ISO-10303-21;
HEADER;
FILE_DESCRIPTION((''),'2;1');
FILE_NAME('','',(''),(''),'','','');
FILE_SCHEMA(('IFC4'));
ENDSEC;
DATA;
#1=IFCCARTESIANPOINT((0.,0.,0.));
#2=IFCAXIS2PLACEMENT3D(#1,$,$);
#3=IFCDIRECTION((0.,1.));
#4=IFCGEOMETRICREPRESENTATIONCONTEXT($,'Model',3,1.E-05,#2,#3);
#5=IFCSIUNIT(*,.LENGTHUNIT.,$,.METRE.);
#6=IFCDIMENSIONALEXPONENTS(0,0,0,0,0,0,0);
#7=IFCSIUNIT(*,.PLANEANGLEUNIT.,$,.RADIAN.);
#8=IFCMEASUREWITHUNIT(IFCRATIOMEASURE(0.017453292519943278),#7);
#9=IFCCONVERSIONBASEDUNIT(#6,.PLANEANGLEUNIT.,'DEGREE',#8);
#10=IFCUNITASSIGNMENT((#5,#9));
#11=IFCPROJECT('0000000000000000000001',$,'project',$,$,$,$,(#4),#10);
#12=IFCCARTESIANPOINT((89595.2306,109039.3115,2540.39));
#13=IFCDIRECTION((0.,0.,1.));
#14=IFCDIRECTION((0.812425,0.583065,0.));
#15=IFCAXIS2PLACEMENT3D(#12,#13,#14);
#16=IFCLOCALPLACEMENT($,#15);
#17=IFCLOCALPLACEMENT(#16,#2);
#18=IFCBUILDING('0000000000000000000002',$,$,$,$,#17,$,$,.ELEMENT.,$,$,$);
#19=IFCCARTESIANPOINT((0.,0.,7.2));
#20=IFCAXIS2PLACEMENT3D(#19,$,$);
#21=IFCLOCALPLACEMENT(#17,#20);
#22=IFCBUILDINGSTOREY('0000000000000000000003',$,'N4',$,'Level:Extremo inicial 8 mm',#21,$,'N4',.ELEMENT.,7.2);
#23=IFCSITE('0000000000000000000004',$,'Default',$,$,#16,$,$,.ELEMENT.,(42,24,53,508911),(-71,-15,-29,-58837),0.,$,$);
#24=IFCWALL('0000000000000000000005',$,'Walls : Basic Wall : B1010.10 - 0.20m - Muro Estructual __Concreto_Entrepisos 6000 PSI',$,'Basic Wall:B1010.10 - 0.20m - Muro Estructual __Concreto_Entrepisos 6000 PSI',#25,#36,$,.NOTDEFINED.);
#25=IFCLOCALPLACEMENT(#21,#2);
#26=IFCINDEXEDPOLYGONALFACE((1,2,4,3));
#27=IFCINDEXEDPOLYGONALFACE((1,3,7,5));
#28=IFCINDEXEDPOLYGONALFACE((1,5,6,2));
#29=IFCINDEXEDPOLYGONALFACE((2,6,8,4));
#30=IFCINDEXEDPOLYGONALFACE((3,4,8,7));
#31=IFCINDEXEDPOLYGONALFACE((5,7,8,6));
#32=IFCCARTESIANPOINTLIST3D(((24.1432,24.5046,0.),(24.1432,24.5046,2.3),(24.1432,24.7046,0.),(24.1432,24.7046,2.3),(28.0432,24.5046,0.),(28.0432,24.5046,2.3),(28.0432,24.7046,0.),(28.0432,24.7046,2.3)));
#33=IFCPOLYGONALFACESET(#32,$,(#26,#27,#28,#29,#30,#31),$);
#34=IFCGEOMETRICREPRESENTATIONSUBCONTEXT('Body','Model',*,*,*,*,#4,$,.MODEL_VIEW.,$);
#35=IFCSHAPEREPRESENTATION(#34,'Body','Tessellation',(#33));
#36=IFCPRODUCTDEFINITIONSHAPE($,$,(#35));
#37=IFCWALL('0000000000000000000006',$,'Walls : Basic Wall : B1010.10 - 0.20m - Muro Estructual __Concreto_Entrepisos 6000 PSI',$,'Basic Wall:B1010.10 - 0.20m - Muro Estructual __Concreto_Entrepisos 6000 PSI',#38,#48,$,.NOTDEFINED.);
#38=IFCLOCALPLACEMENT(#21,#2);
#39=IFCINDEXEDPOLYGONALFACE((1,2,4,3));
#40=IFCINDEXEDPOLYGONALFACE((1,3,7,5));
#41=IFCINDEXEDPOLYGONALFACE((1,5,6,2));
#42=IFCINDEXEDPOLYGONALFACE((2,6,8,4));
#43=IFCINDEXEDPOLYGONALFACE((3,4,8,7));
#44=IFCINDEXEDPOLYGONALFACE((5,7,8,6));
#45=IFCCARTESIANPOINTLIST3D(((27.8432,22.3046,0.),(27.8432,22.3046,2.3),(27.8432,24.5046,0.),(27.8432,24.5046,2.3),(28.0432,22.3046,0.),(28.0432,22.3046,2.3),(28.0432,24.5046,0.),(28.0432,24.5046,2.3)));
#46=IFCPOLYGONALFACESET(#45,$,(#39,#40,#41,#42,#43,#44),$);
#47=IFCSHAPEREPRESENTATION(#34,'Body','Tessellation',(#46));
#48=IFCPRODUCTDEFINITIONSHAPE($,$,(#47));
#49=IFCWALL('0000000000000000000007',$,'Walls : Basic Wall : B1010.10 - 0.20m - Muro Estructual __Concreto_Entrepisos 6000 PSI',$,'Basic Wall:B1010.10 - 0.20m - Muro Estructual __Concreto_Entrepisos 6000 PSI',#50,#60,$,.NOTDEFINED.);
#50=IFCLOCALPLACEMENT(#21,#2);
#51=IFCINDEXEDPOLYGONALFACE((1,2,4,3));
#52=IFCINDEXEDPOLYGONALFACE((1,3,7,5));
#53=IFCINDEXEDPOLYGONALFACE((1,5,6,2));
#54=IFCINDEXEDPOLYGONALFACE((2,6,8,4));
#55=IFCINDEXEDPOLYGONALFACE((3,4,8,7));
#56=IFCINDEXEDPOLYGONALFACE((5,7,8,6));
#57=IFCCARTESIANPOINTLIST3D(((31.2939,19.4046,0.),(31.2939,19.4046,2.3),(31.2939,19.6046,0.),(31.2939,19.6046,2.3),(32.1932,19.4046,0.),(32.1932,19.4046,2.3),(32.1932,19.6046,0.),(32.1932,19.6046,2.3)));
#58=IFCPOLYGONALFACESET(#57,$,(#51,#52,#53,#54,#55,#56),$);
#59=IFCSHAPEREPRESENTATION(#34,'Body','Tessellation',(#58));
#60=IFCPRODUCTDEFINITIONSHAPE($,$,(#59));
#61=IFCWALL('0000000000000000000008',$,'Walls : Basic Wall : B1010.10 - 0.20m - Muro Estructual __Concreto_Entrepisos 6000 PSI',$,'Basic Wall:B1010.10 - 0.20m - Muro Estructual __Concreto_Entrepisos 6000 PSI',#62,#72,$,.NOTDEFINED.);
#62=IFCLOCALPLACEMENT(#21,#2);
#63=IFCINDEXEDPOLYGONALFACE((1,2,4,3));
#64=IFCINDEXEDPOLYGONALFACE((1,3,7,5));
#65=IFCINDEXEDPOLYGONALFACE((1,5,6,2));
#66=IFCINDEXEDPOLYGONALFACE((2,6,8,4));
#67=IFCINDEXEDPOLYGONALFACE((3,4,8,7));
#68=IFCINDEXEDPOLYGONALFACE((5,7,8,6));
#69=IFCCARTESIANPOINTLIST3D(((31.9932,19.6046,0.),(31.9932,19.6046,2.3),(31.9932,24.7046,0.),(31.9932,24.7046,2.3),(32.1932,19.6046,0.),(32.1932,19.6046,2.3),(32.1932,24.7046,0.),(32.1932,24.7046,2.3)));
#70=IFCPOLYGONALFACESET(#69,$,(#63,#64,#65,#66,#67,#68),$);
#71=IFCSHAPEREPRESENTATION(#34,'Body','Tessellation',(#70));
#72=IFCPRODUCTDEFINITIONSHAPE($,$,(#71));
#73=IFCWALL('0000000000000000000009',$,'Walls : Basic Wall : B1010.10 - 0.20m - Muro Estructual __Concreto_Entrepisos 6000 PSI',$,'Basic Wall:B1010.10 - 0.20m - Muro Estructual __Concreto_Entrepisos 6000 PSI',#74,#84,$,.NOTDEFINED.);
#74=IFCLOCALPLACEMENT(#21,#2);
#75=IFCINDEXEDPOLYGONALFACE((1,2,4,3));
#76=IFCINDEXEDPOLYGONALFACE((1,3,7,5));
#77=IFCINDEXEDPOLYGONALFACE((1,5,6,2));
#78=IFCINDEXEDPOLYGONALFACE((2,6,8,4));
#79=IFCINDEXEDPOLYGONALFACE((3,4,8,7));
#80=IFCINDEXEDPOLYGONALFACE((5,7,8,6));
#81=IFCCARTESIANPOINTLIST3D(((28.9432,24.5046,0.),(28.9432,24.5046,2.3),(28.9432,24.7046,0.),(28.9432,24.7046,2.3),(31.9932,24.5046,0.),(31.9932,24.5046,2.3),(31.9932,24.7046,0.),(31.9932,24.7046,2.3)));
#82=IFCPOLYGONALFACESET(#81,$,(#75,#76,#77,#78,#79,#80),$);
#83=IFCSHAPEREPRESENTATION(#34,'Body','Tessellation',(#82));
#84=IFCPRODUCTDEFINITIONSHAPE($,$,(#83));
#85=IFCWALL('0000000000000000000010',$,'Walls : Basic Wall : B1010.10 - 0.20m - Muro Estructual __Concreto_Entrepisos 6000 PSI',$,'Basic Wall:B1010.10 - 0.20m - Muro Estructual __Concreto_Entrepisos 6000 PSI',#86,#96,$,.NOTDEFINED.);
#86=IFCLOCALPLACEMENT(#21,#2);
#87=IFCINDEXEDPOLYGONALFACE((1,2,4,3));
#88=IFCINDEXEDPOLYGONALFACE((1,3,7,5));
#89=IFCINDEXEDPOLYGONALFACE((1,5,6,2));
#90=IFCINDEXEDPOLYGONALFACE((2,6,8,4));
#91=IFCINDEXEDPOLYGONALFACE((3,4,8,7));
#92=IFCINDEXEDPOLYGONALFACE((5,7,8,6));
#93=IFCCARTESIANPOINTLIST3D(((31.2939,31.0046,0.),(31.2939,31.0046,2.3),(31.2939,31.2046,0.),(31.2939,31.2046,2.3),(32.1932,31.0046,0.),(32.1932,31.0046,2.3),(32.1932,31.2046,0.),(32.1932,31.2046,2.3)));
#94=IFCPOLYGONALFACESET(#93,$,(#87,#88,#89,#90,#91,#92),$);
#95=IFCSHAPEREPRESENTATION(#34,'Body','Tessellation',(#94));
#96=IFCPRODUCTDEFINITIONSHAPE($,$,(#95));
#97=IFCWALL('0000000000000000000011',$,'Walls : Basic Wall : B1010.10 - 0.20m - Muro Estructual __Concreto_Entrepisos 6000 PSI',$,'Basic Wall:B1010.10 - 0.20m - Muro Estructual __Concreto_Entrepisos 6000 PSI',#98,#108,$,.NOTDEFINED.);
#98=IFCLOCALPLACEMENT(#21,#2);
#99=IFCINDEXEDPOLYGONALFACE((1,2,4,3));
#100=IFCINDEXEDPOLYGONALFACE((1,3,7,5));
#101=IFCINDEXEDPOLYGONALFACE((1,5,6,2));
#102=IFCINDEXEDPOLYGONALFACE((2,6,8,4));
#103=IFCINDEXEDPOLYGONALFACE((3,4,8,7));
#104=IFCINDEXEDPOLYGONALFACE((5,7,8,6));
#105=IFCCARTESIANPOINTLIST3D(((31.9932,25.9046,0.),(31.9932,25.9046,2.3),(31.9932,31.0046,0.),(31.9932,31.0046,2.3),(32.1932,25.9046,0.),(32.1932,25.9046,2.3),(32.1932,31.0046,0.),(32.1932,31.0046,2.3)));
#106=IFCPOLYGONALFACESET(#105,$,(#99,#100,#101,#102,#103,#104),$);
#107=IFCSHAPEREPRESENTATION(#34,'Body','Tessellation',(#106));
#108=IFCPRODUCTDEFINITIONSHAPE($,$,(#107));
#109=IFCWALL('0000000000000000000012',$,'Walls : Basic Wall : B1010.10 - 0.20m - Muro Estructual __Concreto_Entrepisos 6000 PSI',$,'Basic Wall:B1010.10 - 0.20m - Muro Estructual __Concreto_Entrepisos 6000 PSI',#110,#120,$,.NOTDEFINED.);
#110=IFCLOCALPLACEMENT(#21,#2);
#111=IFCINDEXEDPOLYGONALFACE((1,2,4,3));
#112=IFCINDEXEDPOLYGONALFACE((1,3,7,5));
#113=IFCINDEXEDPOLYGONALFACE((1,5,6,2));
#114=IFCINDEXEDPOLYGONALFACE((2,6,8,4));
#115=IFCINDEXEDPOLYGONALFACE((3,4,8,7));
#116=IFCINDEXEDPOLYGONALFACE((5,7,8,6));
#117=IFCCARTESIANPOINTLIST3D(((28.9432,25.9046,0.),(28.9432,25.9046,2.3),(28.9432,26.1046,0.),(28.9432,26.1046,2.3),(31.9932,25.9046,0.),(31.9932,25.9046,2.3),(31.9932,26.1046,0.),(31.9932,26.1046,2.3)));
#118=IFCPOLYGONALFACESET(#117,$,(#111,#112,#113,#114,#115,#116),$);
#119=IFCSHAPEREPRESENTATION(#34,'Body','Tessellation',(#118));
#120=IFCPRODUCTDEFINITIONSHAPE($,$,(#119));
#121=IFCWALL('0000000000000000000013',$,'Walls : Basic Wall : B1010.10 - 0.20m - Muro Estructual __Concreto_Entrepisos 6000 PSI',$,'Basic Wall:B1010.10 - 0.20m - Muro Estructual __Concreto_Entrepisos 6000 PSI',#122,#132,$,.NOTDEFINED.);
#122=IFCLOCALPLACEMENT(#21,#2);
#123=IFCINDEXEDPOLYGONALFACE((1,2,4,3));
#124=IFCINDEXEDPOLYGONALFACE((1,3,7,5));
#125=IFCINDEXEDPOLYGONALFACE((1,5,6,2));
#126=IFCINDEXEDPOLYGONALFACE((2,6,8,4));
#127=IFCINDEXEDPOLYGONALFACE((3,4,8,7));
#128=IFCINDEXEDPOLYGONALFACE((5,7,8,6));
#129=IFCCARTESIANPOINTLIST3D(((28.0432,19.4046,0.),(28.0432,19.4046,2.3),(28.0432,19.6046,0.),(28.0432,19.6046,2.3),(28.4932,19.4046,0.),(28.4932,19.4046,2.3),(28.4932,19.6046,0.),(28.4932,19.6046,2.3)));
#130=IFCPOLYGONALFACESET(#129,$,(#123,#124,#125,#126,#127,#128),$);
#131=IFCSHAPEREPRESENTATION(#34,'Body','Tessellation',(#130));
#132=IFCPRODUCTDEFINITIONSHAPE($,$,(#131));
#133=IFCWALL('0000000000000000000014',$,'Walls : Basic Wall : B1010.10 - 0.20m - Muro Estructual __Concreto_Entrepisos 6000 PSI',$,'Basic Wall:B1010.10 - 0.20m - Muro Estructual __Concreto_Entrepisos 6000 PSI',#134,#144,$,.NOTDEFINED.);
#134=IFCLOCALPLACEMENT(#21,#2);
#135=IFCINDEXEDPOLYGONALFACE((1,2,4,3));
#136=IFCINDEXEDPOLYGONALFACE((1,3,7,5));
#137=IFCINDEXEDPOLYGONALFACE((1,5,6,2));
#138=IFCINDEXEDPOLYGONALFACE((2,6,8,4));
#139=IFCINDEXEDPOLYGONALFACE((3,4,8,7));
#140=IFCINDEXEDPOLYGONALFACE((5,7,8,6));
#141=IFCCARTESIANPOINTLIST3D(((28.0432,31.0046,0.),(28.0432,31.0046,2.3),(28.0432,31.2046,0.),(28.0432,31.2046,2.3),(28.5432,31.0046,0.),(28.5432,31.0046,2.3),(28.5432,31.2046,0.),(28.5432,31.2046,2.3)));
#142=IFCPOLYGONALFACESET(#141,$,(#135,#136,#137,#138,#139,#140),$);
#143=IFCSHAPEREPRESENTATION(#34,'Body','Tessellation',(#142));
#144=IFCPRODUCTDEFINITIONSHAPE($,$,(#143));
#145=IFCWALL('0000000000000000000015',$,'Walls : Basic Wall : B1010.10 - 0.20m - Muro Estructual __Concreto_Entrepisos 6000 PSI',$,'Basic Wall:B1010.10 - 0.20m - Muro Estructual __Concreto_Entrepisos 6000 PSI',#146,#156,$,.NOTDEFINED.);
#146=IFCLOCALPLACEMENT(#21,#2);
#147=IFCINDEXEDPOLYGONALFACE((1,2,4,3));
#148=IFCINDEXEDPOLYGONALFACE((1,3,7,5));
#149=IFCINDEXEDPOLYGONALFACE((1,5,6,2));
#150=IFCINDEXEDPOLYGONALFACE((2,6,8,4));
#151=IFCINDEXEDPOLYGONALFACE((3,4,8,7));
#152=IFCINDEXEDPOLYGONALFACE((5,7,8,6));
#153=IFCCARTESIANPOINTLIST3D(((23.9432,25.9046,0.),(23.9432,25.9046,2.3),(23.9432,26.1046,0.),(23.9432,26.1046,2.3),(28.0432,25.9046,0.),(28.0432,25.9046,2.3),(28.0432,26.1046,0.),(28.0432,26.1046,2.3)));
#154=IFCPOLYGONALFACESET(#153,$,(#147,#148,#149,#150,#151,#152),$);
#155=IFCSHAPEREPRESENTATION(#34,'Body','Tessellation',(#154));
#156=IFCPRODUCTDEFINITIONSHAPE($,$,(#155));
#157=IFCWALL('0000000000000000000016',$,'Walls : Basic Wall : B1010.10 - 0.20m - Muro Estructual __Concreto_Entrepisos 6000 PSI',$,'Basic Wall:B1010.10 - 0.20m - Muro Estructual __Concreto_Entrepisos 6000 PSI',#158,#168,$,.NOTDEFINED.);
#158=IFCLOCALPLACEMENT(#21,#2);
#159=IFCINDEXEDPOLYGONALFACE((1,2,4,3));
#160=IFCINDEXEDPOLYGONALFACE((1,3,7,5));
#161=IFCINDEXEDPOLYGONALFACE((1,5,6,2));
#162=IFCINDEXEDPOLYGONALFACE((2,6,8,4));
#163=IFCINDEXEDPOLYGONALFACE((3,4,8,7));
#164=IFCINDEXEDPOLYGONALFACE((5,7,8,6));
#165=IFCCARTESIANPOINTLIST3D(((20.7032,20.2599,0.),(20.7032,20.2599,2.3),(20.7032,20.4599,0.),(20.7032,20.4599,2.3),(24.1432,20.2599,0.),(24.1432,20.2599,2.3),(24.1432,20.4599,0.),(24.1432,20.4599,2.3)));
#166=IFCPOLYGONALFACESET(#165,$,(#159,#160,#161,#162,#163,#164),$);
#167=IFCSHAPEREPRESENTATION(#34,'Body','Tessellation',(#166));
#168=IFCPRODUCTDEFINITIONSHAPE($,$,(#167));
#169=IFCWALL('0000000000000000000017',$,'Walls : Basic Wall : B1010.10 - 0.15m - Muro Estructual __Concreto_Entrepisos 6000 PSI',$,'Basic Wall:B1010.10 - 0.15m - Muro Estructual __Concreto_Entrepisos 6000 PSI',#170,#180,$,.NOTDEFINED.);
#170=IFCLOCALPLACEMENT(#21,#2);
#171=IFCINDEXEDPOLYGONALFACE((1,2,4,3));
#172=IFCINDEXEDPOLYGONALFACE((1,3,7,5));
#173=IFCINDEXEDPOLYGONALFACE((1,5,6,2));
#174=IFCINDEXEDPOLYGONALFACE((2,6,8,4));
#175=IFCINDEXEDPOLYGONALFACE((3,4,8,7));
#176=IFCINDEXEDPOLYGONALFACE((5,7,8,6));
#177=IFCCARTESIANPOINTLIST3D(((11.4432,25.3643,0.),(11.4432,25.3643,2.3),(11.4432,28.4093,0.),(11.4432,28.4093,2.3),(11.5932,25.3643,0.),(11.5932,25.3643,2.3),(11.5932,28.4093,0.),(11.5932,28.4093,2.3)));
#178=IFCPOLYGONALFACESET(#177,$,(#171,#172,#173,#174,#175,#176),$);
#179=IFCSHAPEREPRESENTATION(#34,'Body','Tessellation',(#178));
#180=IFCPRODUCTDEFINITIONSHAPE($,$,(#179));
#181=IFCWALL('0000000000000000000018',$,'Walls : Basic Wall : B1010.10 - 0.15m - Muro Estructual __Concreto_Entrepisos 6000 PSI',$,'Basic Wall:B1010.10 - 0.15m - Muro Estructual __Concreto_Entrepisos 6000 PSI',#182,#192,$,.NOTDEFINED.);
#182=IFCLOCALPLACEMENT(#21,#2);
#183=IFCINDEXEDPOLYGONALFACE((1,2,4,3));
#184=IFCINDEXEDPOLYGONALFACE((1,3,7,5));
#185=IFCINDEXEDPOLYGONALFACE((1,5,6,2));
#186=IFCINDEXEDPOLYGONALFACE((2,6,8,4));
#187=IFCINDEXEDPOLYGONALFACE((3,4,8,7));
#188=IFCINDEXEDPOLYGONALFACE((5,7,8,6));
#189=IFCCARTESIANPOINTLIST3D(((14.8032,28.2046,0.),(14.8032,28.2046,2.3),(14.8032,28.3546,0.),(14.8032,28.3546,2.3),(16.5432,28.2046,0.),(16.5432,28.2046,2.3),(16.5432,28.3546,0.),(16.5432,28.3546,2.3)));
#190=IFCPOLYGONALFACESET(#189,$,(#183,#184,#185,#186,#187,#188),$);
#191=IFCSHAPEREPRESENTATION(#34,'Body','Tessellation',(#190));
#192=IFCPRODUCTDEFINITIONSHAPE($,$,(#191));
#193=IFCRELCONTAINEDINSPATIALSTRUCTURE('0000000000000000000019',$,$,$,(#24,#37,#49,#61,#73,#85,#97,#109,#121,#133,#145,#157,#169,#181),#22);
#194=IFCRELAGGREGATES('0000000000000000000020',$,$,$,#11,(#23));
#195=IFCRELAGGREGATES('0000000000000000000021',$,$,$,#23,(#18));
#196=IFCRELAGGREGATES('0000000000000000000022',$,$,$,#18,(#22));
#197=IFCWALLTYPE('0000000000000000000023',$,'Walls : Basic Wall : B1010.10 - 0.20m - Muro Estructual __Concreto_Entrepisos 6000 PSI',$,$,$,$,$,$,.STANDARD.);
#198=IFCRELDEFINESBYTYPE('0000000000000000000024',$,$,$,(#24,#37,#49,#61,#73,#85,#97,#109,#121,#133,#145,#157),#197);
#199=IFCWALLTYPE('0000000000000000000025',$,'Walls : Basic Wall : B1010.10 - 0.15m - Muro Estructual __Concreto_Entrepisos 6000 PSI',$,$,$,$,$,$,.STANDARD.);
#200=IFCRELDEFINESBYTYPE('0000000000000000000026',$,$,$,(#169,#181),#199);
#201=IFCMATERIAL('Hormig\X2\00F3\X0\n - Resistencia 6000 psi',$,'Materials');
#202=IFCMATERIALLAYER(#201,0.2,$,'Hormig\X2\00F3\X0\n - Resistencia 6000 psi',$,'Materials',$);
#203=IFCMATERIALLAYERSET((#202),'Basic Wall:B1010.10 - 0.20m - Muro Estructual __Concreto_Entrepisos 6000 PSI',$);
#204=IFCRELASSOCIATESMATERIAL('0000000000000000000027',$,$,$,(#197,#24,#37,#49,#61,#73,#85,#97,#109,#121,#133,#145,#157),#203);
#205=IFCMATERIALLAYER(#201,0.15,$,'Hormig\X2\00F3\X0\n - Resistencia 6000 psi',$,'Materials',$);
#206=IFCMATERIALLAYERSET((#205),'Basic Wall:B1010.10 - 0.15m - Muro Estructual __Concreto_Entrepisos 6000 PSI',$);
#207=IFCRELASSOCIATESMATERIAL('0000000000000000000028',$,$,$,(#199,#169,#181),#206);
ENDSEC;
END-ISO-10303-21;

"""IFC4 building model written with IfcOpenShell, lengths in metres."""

from ifc_helpers import new_model, entity, si_unit, converted_unit, direction, frame, frame_2d, origin, place, context, subcontext, project, spatial, rectangle, extrude, material, layer, layer_set, layer_usage, type_object, element, save


model = new_model("IFC4")

# Units and contexts
model_context = context("Model", 3, precision=1e-05, world=origin(), true_north=direction((0.0, 1.0)))
body_context = subcontext(model_context, "Body", "Model", "MODEL_VIEW")
ifc_project = project(units=[si_unit("LENGTHUNIT", "METRE"), converted_unit("PLANEANGLEUNIT", "DEGREE", entity("IfcRatioMeasure", 0.017453292519943278), si_unit("PLANEANGLEUNIT", "RADIAN"), dimensions=[0, 0, 0, 0, 0, 0, 0])], contexts=[model_context])

# Site, building, storey
site_placement = place(None, frame((89595.2306, 109039.3115, 2540.39), z_axis=(0.0, 0.0, 1.0), x_axis=(0.812425, 0.583065, 0.0)))
site = spatial("IfcSite", under=ifc_project, at=site_placement, Name="Default", CompositionType="ELEMENT", RefLatitude=(42, 24, 53, 508911), RefLongitude=(-71, -15, -29, -58837), RefElevation=0.0)
building_placement = place(site_placement, origin())
building = spatial("IfcBuilding", under=site, at=building_placement, CompositionType="ELEMENT")
storey_placement = place(building_placement, frame((0.0, 0.0, 7.2)))
storey = spatial("IfcBuildingStorey", under=building, at=storey_placement, Name="N4", ObjectType="Level:Extremo inicial 8 mm", LongName="N4", CompositionType="ELEMENT", Elevation=7.2)

# Walls
ifc_material_1 = material(Name="Hormigón - Resistencia 6000 psi", Category="Materials")
ifc_layer_1 = layer(ifc_material_1, 0.2, Name="Hormigón - Resistencia 6000 psi", Category="Materials")
ifc_layer_set_1 = layer_set([ifc_layer_1], Name="Basic Wall:B1010.10 - 0.20m - Muro Estructual __Concreto_Entrepisos 6000 PSI")
wall_type_1 = type_object("IfcWallType", Name="Walls : Basic Wall : B1010.10 - 0.20m - Muro Estructual __Concreto_Entrepisos 6000 PSI", PredefinedType="STANDARD", material=ifc_layer_set_1)
ifc_layer_usage_1 = layer_usage(ifc_layer_set_1, "AXIS2", "NEGATIVE", 0.1)
wall_1_placement = place(storey_placement, frame((24.1432, 24.6046, 0.0)))
element("IfcWall", 1, at=wall_1_placement, inside=storey, type_object=wall_type_1, material=ifc_layer_usage_1, Name="Walls : Basic Wall : B1010.10 - 0.20m - Muro Estructual __Concreto_Entrepisos 6000 PSI", ObjectType="Basic Wall:B1010.10 - 0.20m - Muro Estructual __Concreto_Entrepisos 6000 PSI", PredefinedType="NOTDEFINED", context=body_context, shape_type="SweptSolid", body=[
    extrude(rectangle(XDim=3.9, YDim=0.2, at=frame_2d((1.95, 0.0), x_axis=(-1.0, 0.0))), origin(), (0.0, 0.0, 1.0), 2.3),
])
ifc_layer_usage_2 = layer_usage(ifc_layer_set_1, "AXIS2", "NEGATIVE", 0.1)
wall_2_placement = place(storey_placement, frame((27.9432, 24.5046, 0.0), z_axis=(0.0, 0.0, 1.0), x_axis=(0.0, -1.0, 0.0)))
element("IfcWall", 2, at=wall_2_placement, inside=storey, type_object=wall_type_1, material=ifc_layer_usage_2, Name="Walls : Basic Wall : B1010.10 - 0.20m - Muro Estructual __Concreto_Entrepisos 6000 PSI", ObjectType="Basic Wall:B1010.10 - 0.20m - Muro Estructual __Concreto_Entrepisos 6000 PSI", PredefinedType="NOTDEFINED", context=body_context, shape_type="SweptSolid", body=[
    extrude(rectangle(XDim=2.2, YDim=0.2, at=frame_2d((1.1, 0.0), x_axis=(-1.0, 0.0))), origin(), (0.0, 0.0, 1.0), 2.3),
])
ifc_layer_usage_3 = layer_usage(ifc_layer_set_1, "AXIS2", "NEGATIVE", 0.1)
wall_3_placement = place(storey_placement, frame((31.2939, 19.5046, 0.0)))
element("IfcWall", 3, at=wall_3_placement, inside=storey, type_object=wall_type_1, material=ifc_layer_usage_3, Name="Walls : Basic Wall : B1010.10 - 0.20m - Muro Estructual __Concreto_Entrepisos 6000 PSI", ObjectType="Basic Wall:B1010.10 - 0.20m - Muro Estructual __Concreto_Entrepisos 6000 PSI", PredefinedType="NOTDEFINED", context=body_context, shape_type="SweptSolid", body=[
    extrude(rectangle(XDim=0.8993, YDim=0.2, at=frame_2d((0.4497, 0.0), x_axis=(-1.0, 0.0))), origin(), (0.0, 0.0, 1.0), 2.3),
])
ifc_layer_usage_4 = layer_usage(ifc_layer_set_1, "AXIS2", "NEGATIVE", 0.1)
wall_4_placement = place(storey_placement, frame((32.0932, 19.6046, 0.0), z_axis=(0.0, 0.0, 1.0), x_axis=(0.0, 1.0, 0.0)))
element("IfcWall", 4, at=wall_4_placement, inside=storey, type_object=wall_type_1, material=ifc_layer_usage_4, Name="Walls : Basic Wall : B1010.10 - 0.20m - Muro Estructual __Concreto_Entrepisos 6000 PSI", ObjectType="Basic Wall:B1010.10 - 0.20m - Muro Estructual __Concreto_Entrepisos 6000 PSI", PredefinedType="NOTDEFINED", context=body_context, shape_type="SweptSolid", body=[
    extrude(rectangle(XDim=5.1, YDim=0.2, at=frame_2d((2.55, 0.0), x_axis=(-1.0, 0.0))), origin(), (0.0, 0.0, 1.0), 2.3),
])
ifc_layer_usage_5 = layer_usage(ifc_layer_set_1, "AXIS2", "NEGATIVE", 0.1)
wall_5_placement = place(storey_placement, frame((31.9932, 24.6046, 0.0), z_axis=(0.0, 0.0, 1.0), x_axis=(-1.0, 0.0, 0.0)))
element("IfcWall", 5, at=wall_5_placement, inside=storey, type_object=wall_type_1, material=ifc_layer_usage_5, Name="Walls : Basic Wall : B1010.10 - 0.20m - Muro Estructual __Concreto_Entrepisos 6000 PSI", ObjectType="Basic Wall:B1010.10 - 0.20m - Muro Estructual __Concreto_Entrepisos 6000 PSI", PredefinedType="NOTDEFINED", context=body_context, shape_type="SweptSolid", body=[
    extrude(rectangle(XDim=3.05, YDim=0.2, at=frame_2d((1.525, 0.0), x_axis=(-1.0, 0.0))), origin(), (0.0, 0.0, 1.0), 2.3),
])
ifc_layer_usage_6 = layer_usage(ifc_layer_set_1, "AXIS2", "POSITIVE", -0.1)
wall_6_placement = place(storey_placement, frame((31.2939, 31.1046, 0.0)))
element("IfcWall", 6, at=wall_6_placement, inside=storey, type_object=wall_type_1, material=ifc_layer_usage_6, Name="Walls : Basic Wall : B1010.10 - 0.20m - Muro Estructual __Concreto_Entrepisos 6000 PSI", ObjectType="Basic Wall:B1010.10 - 0.20m - Muro Estructual __Concreto_Entrepisos 6000 PSI", PredefinedType="NOTDEFINED", context=body_context, shape_type="SweptSolid", body=[
    extrude(rectangle(XDim=0.8993, YDim=0.2, at=frame_2d((0.4497, 0.0), x_axis=(-1.0, 0.0))), origin(), (0.0, 0.0, 1.0), 2.3),
])
ifc_layer_usage_7 = layer_usage(ifc_layer_set_1, "AXIS2", "POSITIVE", -0.1)
wall_7_placement = place(storey_placement, frame((32.0932, 31.0046, 0.0), z_axis=(0.0, 0.0, 1.0), x_axis=(0.0, -1.0, 0.0)))
element("IfcWall", 7, at=wall_7_placement, inside=storey, type_object=wall_type_1, material=ifc_layer_usage_7, Name="Walls : Basic Wall : B1010.10 - 0.20m - Muro Estructual __Concreto_Entrepisos 6000 PSI", ObjectType="Basic Wall:B1010.10 - 0.20m - Muro Estructual __Concreto_Entrepisos 6000 PSI", PredefinedType="NOTDEFINED", context=body_context, shape_type="SweptSolid", body=[
    extrude(rectangle(XDim=5.1, YDim=0.2, at=frame_2d((2.55, 0.0), x_axis=(-1.0, 0.0))), origin(), (0.0, 0.0, 1.0), 2.3),
])
ifc_layer_usage_8 = layer_usage(ifc_layer_set_1, "AXIS2", "POSITIVE", -0.1)
wall_8_placement = place(storey_placement, frame((31.9932, 26.0046, 0.0), z_axis=(0.0, 0.0, 1.0), x_axis=(-1.0, 0.0, 0.0)))
element("IfcWall", 8, at=wall_8_placement, inside=storey, type_object=wall_type_1, material=ifc_layer_usage_8, Name="Walls : Basic Wall : B1010.10 - 0.20m - Muro Estructual __Concreto_Entrepisos 6000 PSI", ObjectType="Basic Wall:B1010.10 - 0.20m - Muro Estructual __Concreto_Entrepisos 6000 PSI", PredefinedType="NOTDEFINED", context=body_context, shape_type="SweptSolid", body=[
    extrude(rectangle(XDim=3.05, YDim=0.2, at=frame_2d((1.525, 0.0), x_axis=(-1.0, 0.0))), origin(), (0.0, 0.0, 1.0), 2.3),
])
ifc_layer_usage_9 = layer_usage(ifc_layer_set_1, "AXIS2", "NEGATIVE", 0.1)
wall_9_placement = place(storey_placement, frame((28.4932, 19.5046, 0.0), z_axis=(0.0, 0.0, 1.0), x_axis=(-1.0, 0.0, 0.0)))
element("IfcWall", 9, at=wall_9_placement, inside=storey, type_object=wall_type_1, material=ifc_layer_usage_9, Name="Walls : Basic Wall : B1010.10 - 0.20m - Muro Estructual __Concreto_Entrepisos 6000 PSI", ObjectType="Basic Wall:B1010.10 - 0.20m - Muro Estructual __Concreto_Entrepisos 6000 PSI", PredefinedType="NOTDEFINED", context=body_context, shape_type="SweptSolid", body=[
    extrude(rectangle(XDim=0.45, YDim=0.2, at=frame_2d((0.225, 0.0), x_axis=(-1.0, 0.0))), origin(), (0.0, 0.0, 1.0), 2.3),
])
ifc_layer_usage_10 = layer_usage(ifc_layer_set_1, "AXIS2", "NEGATIVE", 0.1)
wall_10_placement = place(storey_placement, frame((28.5432, 31.1046, 0.0), z_axis=(0.0, 0.0, 1.0), x_axis=(-1.0, 0.0, 0.0)))
element("IfcWall", 10, at=wall_10_placement, inside=storey, type_object=wall_type_1, material=ifc_layer_usage_10, Name="Walls : Basic Wall : B1010.10 - 0.20m - Muro Estructual __Concreto_Entrepisos 6000 PSI", ObjectType="Basic Wall:B1010.10 - 0.20m - Muro Estructual __Concreto_Entrepisos 6000 PSI", PredefinedType="NOTDEFINED", context=body_context, shape_type="SweptSolid", body=[
    extrude(rectangle(XDim=0.5, YDim=0.2, at=frame_2d((0.25, 0.0), x_axis=(-1.0, 0.0))), origin(), (0.0, 0.0, 1.0), 2.3),
])
ifc_layer_usage_11 = layer_usage(ifc_layer_set_1, "AXIS2", "NEGATIVE", 0.1)
wall_11_placement = place(storey_placement, frame((23.9432, 26.0046, 0.0)))
element("IfcWall", 11, at=wall_11_placement, inside=storey, type_object=wall_type_1, material=ifc_layer_usage_11, Name="Walls : Basic Wall : B1010.10 - 0.20m - Muro Estructual __Concreto_Entrepisos 6000 PSI", ObjectType="Basic Wall:B1010.10 - 0.20m - Muro Estructual __Concreto_Entrepisos 6000 PSI", PredefinedType="NOTDEFINED", context=body_context, shape_type="SweptSolid", body=[
    extrude(rectangle(XDim=4.1, YDim=0.2, at=frame_2d((2.05, 0.0), x_axis=(-1.0, 0.0))), origin(), (0.0, 0.0, 1.0), 2.3),
])
ifc_layer_usage_12 = layer_usage(ifc_layer_set_1, "AXIS2", "NEGATIVE", 0.1)
wall_12_placement = place(storey_placement, frame((20.7032, 20.3599, 0.0)))
element("IfcWall", 12, at=wall_12_placement, inside=storey, type_object=wall_type_1, material=ifc_layer_usage_12, Name="Walls : Basic Wall : B1010.10 - 0.20m - Muro Estructual __Concreto_Entrepisos 6000 PSI", ObjectType="Basic Wall:B1010.10 - 0.20m - Muro Estructual __Concreto_Entrepisos 6000 PSI", PredefinedType="NOTDEFINED", context=body_context, shape_type="SweptSolid", body=[
    extrude(rectangle(XDim=3.44, YDim=0.2, at=frame_2d((1.72, 0.0), x_axis=(-1.0, 0.0))), origin(), (0.0, 0.0, 1.0), 2.3),
])
ifc_layer_2 = layer(ifc_material_1, 0.15, Name="Hormigón - Resistencia 6000 psi", Category="Materials")
ifc_layer_set_2 = layer_set([ifc_layer_2], Name="Basic Wall:B1010.10 - 0.15m - Muro Estructual __Concreto_Entrepisos 6000 PSI")
ifc_layer_usage_13 = layer_usage(ifc_layer_set_2, "AXIS2", "NEGATIVE", 0.075)
wall_type_2 = type_object("IfcWallType", Name="Walls : Basic Wall : B1010.10 - 0.15m - Muro Estructual __Concreto_Entrepisos 6000 PSI", PredefinedType="STANDARD", material=ifc_layer_set_2)
wall_13_placement = place(storey_placement, frame((11.5182, 25.3643, 0.0), z_axis=(0.0, 0.0, 1.0), x_axis=(0.0, 1.0, 0.0)))
element("IfcWall", 13, at=wall_13_placement, inside=storey, type_object=wall_type_2, material=ifc_layer_usage_13, Name="Walls : Basic Wall : B1010.10 - 0.15m - Muro Estructual __Concreto_Entrepisos 6000 PSI", ObjectType="Basic Wall:B1010.10 - 0.15m - Muro Estructual __Concreto_Entrepisos 6000 PSI", PredefinedType="NOTDEFINED", context=body_context, shape_type="SweptSolid", body=[
    extrude(rectangle(XDim=3.045, YDim=0.15, at=frame_2d((1.5225, 0.0), x_axis=(-1.0, 0.0))), origin(), (0.0, 0.0, 1.0), 2.3),
])
ifc_layer_usage_14 = layer_usage(ifc_layer_set_2, "AXIS2", "NEGATIVE", 0.075)
wall_14_placement = place(storey_placement, frame((16.5432, 28.2796, 0.0), z_axis=(0.0, 0.0, 1.0), x_axis=(-1.0, 0.0, 0.0)))
element("IfcWall", 14, at=wall_14_placement, inside=storey, type_object=wall_type_2, material=ifc_layer_usage_14, Name="Walls : Basic Wall : B1010.10 - 0.15m - Muro Estructual __Concreto_Entrepisos 6000 PSI", ObjectType="Basic Wall:B1010.10 - 0.15m - Muro Estructual __Concreto_Entrepisos 6000 PSI", PredefinedType="NOTDEFINED", context=body_context, shape_type="SweptSolid", body=[
    extrude(rectangle(XDim=1.74, YDim=0.15, at=frame_2d((0.87, 0.0), x_axis=(-1.0, 0.0))), origin(), (0.0, 0.0, 1.0), 2.3),
])

save(model, "model.ifc")
